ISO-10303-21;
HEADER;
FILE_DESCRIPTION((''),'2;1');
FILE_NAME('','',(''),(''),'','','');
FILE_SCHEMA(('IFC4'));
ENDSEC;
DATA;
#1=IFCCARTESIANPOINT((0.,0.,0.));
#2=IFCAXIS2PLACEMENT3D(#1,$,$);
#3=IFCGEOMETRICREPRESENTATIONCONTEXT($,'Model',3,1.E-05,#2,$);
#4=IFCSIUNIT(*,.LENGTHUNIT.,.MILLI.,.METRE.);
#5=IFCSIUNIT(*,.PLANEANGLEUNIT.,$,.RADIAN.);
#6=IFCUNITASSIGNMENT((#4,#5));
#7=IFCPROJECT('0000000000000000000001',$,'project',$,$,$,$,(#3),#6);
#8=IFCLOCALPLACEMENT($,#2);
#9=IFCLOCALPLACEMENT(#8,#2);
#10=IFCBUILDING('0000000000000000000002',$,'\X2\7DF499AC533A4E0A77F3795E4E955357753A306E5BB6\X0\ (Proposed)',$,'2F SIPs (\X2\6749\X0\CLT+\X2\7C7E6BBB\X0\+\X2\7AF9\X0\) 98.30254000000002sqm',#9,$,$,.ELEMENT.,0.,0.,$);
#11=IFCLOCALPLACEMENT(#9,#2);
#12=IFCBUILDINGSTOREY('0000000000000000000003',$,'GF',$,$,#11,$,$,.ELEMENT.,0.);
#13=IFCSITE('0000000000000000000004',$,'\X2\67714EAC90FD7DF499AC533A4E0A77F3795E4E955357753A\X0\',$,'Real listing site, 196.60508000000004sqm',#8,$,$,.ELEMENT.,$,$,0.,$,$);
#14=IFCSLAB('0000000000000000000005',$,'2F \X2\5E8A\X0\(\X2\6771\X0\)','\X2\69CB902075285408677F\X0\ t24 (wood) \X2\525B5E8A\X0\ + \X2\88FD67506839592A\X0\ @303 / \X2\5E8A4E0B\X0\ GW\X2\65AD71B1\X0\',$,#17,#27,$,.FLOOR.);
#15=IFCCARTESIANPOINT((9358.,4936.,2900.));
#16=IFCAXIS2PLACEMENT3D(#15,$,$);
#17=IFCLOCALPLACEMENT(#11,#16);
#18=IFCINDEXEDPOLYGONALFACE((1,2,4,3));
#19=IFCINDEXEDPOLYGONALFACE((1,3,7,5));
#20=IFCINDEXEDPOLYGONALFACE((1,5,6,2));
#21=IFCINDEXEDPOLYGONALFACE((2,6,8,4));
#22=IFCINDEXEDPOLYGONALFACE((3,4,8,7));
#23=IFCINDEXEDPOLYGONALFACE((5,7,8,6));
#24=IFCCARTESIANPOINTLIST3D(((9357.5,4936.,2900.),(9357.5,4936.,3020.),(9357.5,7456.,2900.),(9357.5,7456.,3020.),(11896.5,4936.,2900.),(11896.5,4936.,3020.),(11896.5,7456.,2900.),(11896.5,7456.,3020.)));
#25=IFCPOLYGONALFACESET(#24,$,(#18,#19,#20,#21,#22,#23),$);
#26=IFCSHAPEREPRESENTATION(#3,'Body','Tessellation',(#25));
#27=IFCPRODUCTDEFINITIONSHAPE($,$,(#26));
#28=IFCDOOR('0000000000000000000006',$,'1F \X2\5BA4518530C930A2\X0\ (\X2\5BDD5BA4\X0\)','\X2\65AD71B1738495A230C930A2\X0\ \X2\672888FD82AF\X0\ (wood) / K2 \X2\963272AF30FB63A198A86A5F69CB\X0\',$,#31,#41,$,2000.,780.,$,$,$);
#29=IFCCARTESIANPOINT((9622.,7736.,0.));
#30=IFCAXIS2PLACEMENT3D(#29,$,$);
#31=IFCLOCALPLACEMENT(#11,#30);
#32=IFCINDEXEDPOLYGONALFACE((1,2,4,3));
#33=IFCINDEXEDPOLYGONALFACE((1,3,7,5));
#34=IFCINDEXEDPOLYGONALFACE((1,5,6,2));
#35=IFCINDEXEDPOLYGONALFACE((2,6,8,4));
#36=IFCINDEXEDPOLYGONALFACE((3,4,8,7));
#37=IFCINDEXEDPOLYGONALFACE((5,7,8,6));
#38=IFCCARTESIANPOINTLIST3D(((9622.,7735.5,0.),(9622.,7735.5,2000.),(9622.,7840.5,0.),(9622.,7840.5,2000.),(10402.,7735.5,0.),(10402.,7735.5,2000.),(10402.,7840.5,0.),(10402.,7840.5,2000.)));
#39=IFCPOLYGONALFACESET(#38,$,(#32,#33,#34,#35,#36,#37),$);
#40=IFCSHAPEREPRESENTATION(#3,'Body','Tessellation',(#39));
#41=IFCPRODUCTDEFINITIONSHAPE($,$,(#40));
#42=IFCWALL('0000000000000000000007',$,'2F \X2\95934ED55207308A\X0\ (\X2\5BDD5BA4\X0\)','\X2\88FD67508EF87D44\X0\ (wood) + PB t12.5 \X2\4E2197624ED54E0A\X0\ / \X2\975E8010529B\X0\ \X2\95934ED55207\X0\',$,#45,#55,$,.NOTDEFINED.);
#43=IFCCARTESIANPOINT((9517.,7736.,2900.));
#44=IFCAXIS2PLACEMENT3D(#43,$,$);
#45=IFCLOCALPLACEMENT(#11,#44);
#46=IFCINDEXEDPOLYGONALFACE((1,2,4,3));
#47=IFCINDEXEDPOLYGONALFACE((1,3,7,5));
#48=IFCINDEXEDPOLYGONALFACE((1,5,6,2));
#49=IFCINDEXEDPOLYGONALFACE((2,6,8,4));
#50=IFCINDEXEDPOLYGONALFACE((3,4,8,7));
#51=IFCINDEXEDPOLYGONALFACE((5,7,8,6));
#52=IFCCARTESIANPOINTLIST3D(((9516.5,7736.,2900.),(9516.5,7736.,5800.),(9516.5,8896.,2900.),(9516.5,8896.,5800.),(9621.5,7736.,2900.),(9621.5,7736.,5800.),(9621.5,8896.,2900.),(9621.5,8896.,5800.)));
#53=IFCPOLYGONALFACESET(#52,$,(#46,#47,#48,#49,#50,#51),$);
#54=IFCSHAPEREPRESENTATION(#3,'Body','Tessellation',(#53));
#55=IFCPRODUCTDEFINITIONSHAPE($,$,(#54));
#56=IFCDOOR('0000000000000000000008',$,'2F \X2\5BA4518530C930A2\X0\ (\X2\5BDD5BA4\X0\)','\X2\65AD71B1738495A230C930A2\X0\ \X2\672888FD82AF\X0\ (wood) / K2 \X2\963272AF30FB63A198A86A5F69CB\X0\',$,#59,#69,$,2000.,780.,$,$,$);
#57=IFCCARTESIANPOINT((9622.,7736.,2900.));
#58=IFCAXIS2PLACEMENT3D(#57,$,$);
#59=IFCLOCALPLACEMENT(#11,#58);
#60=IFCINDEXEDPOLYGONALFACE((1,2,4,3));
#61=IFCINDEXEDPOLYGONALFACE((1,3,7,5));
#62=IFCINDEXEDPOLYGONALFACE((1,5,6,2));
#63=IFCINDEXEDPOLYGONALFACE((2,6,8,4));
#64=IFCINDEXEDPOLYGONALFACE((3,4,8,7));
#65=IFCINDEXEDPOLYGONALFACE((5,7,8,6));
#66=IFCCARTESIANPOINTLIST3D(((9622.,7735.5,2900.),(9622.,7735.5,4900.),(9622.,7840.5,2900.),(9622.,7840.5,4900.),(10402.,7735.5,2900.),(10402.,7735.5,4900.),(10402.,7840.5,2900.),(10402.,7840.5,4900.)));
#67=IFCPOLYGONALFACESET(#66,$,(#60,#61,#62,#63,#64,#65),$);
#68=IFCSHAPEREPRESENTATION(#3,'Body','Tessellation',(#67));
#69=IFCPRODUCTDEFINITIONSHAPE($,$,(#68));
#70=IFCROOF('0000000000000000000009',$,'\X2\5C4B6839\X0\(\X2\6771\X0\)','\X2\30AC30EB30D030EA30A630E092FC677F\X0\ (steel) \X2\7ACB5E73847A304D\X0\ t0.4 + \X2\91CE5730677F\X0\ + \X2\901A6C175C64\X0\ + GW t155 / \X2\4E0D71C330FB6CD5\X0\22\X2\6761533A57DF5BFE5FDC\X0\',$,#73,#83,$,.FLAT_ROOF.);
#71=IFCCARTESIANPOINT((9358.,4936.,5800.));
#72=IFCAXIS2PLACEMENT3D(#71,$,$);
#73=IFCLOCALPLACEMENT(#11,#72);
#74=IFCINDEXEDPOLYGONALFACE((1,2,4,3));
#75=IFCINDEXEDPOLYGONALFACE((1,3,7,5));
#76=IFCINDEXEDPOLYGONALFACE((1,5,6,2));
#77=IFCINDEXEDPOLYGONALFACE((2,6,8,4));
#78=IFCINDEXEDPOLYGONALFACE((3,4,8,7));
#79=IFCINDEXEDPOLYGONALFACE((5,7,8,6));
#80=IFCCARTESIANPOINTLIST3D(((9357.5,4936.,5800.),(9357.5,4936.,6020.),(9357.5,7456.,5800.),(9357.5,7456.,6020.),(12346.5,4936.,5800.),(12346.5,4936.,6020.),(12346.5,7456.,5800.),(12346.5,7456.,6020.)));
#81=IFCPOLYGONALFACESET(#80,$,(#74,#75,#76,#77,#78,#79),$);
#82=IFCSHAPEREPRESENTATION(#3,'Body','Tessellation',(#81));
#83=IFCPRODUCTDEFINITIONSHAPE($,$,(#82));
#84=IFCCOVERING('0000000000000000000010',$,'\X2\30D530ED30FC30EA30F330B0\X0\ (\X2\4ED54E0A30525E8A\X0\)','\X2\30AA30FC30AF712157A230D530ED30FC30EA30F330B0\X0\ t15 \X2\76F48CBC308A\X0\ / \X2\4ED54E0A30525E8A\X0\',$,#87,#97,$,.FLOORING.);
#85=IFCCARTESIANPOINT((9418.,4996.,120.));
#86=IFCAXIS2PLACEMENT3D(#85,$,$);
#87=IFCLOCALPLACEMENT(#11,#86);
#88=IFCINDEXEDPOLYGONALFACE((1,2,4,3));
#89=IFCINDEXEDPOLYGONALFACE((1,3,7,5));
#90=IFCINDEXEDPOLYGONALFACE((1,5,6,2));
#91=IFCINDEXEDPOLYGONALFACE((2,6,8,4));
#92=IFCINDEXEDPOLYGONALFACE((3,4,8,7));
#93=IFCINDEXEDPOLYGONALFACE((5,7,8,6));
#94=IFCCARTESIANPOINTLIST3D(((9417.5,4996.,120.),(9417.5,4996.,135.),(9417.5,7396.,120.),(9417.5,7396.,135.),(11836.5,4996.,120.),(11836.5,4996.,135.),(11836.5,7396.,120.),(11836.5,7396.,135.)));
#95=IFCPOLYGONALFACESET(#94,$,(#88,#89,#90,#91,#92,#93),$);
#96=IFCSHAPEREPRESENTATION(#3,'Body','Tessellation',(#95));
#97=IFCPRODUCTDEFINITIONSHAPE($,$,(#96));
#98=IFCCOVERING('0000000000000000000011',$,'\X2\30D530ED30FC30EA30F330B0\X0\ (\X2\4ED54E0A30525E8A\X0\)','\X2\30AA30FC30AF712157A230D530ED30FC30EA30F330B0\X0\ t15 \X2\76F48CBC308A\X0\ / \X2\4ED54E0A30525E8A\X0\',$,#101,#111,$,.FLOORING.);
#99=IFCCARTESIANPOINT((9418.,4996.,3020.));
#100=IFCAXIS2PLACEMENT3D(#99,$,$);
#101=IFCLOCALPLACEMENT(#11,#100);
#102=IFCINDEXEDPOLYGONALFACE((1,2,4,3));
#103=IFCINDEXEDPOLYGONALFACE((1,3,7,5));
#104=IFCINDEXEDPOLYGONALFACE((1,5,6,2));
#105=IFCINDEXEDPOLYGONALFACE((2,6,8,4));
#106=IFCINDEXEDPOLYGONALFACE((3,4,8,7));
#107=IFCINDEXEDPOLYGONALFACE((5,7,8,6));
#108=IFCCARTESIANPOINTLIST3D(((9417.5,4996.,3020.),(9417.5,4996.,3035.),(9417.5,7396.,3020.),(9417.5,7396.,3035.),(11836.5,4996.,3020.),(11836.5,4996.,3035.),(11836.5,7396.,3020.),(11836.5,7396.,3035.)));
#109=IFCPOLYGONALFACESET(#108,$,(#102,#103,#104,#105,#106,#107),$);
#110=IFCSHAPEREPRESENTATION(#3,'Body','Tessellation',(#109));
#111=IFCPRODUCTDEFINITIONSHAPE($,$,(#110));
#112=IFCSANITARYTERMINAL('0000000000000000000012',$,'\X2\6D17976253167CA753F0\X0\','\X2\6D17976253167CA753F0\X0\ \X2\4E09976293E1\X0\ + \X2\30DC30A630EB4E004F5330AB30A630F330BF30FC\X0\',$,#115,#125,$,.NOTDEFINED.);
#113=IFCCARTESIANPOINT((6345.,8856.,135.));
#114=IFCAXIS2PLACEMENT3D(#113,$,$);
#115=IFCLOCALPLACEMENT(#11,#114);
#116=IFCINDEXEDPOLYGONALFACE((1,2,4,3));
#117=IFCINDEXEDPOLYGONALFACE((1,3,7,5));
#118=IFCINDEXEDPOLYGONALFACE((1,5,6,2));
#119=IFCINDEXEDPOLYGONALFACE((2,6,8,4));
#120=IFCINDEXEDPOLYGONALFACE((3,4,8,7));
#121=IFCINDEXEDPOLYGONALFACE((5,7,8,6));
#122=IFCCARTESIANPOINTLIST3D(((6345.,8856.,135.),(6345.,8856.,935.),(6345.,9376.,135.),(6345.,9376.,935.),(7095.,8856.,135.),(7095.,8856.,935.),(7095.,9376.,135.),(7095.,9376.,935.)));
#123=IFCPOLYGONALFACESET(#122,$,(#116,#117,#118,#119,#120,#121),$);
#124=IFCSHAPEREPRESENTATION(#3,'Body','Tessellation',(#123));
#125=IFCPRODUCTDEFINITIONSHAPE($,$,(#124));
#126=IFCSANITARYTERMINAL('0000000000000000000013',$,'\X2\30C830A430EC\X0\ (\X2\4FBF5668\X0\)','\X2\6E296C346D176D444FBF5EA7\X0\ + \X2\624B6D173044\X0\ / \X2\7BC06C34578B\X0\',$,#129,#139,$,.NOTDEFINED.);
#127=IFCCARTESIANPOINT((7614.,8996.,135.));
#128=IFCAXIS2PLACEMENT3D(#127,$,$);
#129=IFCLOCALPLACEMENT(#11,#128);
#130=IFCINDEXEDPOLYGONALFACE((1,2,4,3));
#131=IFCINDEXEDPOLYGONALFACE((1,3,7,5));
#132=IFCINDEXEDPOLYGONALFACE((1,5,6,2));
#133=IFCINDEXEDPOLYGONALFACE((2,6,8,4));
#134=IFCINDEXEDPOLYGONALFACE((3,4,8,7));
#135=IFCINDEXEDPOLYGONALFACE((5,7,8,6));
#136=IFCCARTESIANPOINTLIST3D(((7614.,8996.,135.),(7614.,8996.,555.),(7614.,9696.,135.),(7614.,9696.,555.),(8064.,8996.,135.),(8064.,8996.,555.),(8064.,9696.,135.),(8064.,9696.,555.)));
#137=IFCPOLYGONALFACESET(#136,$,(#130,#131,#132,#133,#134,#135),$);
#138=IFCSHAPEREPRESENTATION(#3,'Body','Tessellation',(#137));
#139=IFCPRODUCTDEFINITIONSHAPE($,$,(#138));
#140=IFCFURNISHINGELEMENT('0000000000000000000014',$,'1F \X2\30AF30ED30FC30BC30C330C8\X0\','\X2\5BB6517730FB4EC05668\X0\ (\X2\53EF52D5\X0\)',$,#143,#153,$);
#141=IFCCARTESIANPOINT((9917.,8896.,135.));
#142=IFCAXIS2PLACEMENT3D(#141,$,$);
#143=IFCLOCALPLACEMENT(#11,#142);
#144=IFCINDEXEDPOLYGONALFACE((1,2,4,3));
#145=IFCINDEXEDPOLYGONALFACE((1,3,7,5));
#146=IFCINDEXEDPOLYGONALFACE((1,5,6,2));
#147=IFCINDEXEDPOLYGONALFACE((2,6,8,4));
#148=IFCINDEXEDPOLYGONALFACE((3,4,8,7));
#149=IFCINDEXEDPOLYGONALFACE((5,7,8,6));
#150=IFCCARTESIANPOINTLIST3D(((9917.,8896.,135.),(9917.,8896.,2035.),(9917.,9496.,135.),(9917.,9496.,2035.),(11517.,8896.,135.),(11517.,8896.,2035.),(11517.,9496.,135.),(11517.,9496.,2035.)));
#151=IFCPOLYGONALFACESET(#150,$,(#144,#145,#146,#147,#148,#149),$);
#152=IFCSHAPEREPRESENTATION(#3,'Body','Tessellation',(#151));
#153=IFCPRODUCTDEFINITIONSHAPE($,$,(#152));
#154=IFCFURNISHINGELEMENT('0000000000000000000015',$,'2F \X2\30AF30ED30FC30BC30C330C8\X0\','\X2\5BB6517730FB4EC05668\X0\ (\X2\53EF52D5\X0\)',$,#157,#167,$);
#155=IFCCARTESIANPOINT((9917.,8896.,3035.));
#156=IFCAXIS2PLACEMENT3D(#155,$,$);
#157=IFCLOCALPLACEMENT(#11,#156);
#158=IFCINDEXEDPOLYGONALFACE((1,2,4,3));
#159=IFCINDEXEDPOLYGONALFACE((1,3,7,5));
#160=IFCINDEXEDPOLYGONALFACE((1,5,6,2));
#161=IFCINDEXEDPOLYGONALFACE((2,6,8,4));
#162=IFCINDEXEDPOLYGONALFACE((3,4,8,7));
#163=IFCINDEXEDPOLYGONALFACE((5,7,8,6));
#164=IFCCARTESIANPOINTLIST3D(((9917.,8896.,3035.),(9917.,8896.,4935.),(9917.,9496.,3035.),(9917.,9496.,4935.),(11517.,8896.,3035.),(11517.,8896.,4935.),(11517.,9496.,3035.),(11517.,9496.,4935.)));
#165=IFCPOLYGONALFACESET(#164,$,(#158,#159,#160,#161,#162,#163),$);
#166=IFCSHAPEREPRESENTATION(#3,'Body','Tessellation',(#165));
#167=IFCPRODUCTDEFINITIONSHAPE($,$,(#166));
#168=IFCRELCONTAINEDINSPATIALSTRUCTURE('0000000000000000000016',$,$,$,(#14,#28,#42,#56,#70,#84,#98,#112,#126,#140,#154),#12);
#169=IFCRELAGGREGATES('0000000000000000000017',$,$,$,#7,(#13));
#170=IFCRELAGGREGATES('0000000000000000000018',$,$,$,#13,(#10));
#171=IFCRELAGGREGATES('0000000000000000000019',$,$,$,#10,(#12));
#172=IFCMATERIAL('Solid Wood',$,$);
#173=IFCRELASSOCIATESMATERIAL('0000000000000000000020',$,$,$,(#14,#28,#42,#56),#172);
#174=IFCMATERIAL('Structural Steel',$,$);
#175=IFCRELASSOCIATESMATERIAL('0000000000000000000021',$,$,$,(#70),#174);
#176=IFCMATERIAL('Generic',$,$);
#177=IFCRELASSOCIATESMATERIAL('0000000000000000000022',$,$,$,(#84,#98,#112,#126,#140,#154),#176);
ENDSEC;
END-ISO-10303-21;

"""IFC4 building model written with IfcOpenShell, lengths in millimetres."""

from ifc_helpers import new_model, si_unit, frame, frame_2d, origin, place, context, project, spatial, rectangle, extrude, material, element, save


model = new_model("IFC4")

# Units and contexts
model_context = context("Model", 3, precision=1e-05, world=origin())
ifc_project = project(units=[si_unit("LENGTHUNIT", "METRE", prefix="MILLI"), si_unit("PLANEANGLEUNIT", "RADIAN")], contexts=[model_context])

# Site, building, storey
site_placement = place(None, origin())
site = spatial("IfcSite", under=ifc_project, at=site_placement, Name="東京都練馬区上石神井南町", ObjectType="Real listing site, 196.60508000000004sqm", CompositionType="ELEMENT", RefElevation=0.0)
building_placement = place(site_placement, origin())
building = spatial("IfcBuilding", under=site, at=building_placement, Name="練馬区上石神井南町の家 (Proposed)", ObjectType="2F SIPs (杉CLT+籾殻+竹) 98.30254000000002sqm", CompositionType="ELEMENT", ElevationOfRefHeight=0.0, ElevationOfTerrain=0.0)
storey_placement = place(building_placement, origin())
storey = spatial("IfcBuildingStorey", under=building, at=storey_placement, Name="GF", CompositionType="ELEMENT", Elevation=0.0)

# Slab
ifc_material_1 = material(Name="Solid Wood")
slab_1_placement = place(storey_placement, frame((9358.0, 4936.0, 2900.0)))
element("IfcSlab", 1, at=slab_1_placement, inside=storey, material=ifc_material_1, Name="2F 床(東)", Description="構造用合板 t24 (wood) 剛床 + 製材根太 @303 / 床下 GW断熱", PredefinedType="FLOOR", context=model_context, shape_type="SweptSolid", body=[
    extrude(rectangle(XDim=2539.0, YDim=2520.0, at=frame_2d((1269.0, 1260.0))), frame((9358.0, 4936.0, 2900.0)), (0.0, 0.0, 1.0), 120.0),
])

# Door
door_1_placement = place(storey_placement, frame((9622.0, 7736.0, 0.0)))
element("IfcDoor", 2, at=door_1_placement, inside=storey, material=ifc_material_1, Name="1F 室内ドア (寝室)", Description="断熱玄関ドア 木製芯 (wood) / K2 防犯・採風機構", OverallHeight=2000.0, OverallWidth=780.0, context=model_context, shape_type="SweptSolid", body=[
    extrude(rectangle(XDim=780.0, YDim=105.0, at=frame_2d((390.0, 52.0))), frame((9622.0, 7736.0, 0.0)), (0.0, 0.0, 1.0), 2000.0),
])

# Wall
wall_1_placement = place(storey_placement, frame((9517.0, 7736.0, 2900.0)))
element("IfcWall", 3, at=wall_1_placement, inside=storey, material=ifc_material_1, Name="2F 間仕切り (寝室)", Description="製材軸組 (wood) + PB t12.5 両面仕上 / 非耐力 間仕切", PredefinedType="NOTDEFINED", context=model_context, shape_type="SweptSolid", body=[
    extrude(rectangle(XDim=105.0, YDim=1160.0, at=frame_2d((52.0, 580.0))), frame((9517.0, 7736.0, 2900.0)), (0.0, 0.0, 1.0), 2900.0),
])

# Door
door_2_placement = place(storey_placement, frame((9622.0, 7736.0, 2900.0)))
element("IfcDoor", 4, at=door_2_placement, inside=storey, material=ifc_material_1, Name="2F 室内ドア (寝室)", Description="断熱玄関ドア 木製芯 (wood) / K2 防犯・採風機構", OverallHeight=2000.0, OverallWidth=780.0, context=model_context, shape_type="SweptSolid", body=[
    extrude(rectangle(XDim=780.0, YDim=105.0, at=frame_2d((390.0, 52.0))), frame((9622.0, 7736.0, 2900.0)), (0.0, 0.0, 1.0), 2000.0),
])

# Roof
ifc_material_2 = material(Name="Structural Steel")
for number, where, name in (
    (5, (9358.0, 4936.0, 5800.0), "屋根(東)"),
):
    element("IfcRoof", number, at=place(storey_placement, frame(where)), inside=storey, material=ifc_material_2, Name=name, Description="ガルバリウム鋼板 (steel) 立平葺き t0.4 + 野地板 + 通気層 + GW t155 / 不燃・法22条区域対応", PredefinedType="FLAT_ROOF", context=model_context, shape_type="SweptSolid", body=[
        extrude(rectangle(XDim=2989.0, YDim=2520.0, at=frame_2d((1494.0, 1260.0))), frame((9358.0, 4936.0, 5800.0)), (0.0, 0.0, 1.0), 220.0),
    ])

# Coverings
ifc_material_3 = material(Name="Generic")
covering_1_placement = place(storey_placement, frame((9418.0, 4996.0, 120.0)))
element("IfcCovering", 6, at=covering_1_placement, inside=storey, material=ifc_material_3, Name="フローリング (仕上げ床)", Description="オーク無垢フローリング t15 直貼り / 仕上げ床", PredefinedType="FLOORING", context=model_context, shape_type="SweptSolid", body=[
    extrude(rectangle(XDim=2419.0, YDim=2400.0, at=frame_2d((1209.0, 1200.0))), frame((9418.0, 4996.0, 120.0)), (0.0, 0.0, 1.0), 15.0),
])
covering_2_placement = place(storey_placement, frame((9418.0, 4996.0, 3020.0)))
element("IfcCovering", 7, at=covering_2_placement, inside=storey, material=ifc_material_3, Name="フローリング (仕上げ床)", Description="オーク無垢フローリング t15 直貼り / 仕上げ床", PredefinedType="FLOORING", context=model_context, shape_type="SweptSolid", body=[
    extrude(rectangle(XDim=2419.0, YDim=2400.0, at=frame_2d((1209.0, 1200.0))), frame((9418.0, 4996.0, 3020.0)), (0.0, 0.0, 1.0), 15.0),
])

# Sanitary terminals
sanitary_terminal_1_placement = place(storey_placement, frame((6345.0, 8856.0, 135.0)))
element("IfcSanitaryTerminal", 8, at=sanitary_terminal_1_placement, inside=storey, material=ifc_material_3, Name="洗面化粧台", Description="洗面化粧台 三面鏡 + ボウル一体カウンター", PredefinedType="NOTDEFINED", context=model_context, shape_type="SweptSolid", body=[
    extrude(rectangle(XDim=750.0, YDim=520.0, at=frame_2d((375.0, 260.0))), frame((6345.0, 8856.0, 135.0)), (0.0, 0.0, 1.0), 800.0),
])
sanitary_terminal_2_placement = place(storey_placement, frame((7614.0, 8996.0, 135.0)))
element("IfcSanitaryTerminal", 9, at=sanitary_terminal_2_placement, inside=storey, material=ifc_material_3, Name="トイレ (便器)", Description="温水洗浄便座 + 手洗い / 節水型", PredefinedType="NOTDEFINED", context=model_context, shape_type="SweptSolid", body=[
    extrude(rectangle(XDim=450.0, YDim=700.0, at=frame_2d((225.0, 350.0))), frame((7614.0, 8996.0, 135.0)), (0.0, 0.0, 1.0), 420.0),
])

# Furnishing elements
furnishing_1_placement = place(storey_placement, frame((9917.0, 8896.0, 135.0)))
element("IfcFurnishingElement", 10, at=furnishing_1_placement, inside=storey, material=ifc_material_3, Name="1F クローゼット", Description="家具・什器 (可動)", context=model_context, shape_type="SweptSolid", body=[
    extrude(rectangle(XDim=1600.0, YDim=600.0, at=frame_2d((800.0, 300.0))), frame((9917.0, 8896.0, 135.0)), (0.0, 0.0, 1.0), 1900.0),
])
furnishing_2_placement = place(storey_placement, frame((9917.0, 8896.0, 3035.0)))
element("IfcFurnishingElement", 11, at=furnishing_2_placement, inside=storey, material=ifc_material_3, Name="2F クローゼット", Description="家具・什器 (可動)", context=model_context, shape_type="SweptSolid", body=[
    extrude(rectangle(XDim=1600.0, YDim=600.0, at=frame_2d((800.0, 300.0))), frame((9917.0, 8896.0, 3035.0)), (0.0, 0.0, 1.0), 1900.0),
])

save(model, "model.ifc")
